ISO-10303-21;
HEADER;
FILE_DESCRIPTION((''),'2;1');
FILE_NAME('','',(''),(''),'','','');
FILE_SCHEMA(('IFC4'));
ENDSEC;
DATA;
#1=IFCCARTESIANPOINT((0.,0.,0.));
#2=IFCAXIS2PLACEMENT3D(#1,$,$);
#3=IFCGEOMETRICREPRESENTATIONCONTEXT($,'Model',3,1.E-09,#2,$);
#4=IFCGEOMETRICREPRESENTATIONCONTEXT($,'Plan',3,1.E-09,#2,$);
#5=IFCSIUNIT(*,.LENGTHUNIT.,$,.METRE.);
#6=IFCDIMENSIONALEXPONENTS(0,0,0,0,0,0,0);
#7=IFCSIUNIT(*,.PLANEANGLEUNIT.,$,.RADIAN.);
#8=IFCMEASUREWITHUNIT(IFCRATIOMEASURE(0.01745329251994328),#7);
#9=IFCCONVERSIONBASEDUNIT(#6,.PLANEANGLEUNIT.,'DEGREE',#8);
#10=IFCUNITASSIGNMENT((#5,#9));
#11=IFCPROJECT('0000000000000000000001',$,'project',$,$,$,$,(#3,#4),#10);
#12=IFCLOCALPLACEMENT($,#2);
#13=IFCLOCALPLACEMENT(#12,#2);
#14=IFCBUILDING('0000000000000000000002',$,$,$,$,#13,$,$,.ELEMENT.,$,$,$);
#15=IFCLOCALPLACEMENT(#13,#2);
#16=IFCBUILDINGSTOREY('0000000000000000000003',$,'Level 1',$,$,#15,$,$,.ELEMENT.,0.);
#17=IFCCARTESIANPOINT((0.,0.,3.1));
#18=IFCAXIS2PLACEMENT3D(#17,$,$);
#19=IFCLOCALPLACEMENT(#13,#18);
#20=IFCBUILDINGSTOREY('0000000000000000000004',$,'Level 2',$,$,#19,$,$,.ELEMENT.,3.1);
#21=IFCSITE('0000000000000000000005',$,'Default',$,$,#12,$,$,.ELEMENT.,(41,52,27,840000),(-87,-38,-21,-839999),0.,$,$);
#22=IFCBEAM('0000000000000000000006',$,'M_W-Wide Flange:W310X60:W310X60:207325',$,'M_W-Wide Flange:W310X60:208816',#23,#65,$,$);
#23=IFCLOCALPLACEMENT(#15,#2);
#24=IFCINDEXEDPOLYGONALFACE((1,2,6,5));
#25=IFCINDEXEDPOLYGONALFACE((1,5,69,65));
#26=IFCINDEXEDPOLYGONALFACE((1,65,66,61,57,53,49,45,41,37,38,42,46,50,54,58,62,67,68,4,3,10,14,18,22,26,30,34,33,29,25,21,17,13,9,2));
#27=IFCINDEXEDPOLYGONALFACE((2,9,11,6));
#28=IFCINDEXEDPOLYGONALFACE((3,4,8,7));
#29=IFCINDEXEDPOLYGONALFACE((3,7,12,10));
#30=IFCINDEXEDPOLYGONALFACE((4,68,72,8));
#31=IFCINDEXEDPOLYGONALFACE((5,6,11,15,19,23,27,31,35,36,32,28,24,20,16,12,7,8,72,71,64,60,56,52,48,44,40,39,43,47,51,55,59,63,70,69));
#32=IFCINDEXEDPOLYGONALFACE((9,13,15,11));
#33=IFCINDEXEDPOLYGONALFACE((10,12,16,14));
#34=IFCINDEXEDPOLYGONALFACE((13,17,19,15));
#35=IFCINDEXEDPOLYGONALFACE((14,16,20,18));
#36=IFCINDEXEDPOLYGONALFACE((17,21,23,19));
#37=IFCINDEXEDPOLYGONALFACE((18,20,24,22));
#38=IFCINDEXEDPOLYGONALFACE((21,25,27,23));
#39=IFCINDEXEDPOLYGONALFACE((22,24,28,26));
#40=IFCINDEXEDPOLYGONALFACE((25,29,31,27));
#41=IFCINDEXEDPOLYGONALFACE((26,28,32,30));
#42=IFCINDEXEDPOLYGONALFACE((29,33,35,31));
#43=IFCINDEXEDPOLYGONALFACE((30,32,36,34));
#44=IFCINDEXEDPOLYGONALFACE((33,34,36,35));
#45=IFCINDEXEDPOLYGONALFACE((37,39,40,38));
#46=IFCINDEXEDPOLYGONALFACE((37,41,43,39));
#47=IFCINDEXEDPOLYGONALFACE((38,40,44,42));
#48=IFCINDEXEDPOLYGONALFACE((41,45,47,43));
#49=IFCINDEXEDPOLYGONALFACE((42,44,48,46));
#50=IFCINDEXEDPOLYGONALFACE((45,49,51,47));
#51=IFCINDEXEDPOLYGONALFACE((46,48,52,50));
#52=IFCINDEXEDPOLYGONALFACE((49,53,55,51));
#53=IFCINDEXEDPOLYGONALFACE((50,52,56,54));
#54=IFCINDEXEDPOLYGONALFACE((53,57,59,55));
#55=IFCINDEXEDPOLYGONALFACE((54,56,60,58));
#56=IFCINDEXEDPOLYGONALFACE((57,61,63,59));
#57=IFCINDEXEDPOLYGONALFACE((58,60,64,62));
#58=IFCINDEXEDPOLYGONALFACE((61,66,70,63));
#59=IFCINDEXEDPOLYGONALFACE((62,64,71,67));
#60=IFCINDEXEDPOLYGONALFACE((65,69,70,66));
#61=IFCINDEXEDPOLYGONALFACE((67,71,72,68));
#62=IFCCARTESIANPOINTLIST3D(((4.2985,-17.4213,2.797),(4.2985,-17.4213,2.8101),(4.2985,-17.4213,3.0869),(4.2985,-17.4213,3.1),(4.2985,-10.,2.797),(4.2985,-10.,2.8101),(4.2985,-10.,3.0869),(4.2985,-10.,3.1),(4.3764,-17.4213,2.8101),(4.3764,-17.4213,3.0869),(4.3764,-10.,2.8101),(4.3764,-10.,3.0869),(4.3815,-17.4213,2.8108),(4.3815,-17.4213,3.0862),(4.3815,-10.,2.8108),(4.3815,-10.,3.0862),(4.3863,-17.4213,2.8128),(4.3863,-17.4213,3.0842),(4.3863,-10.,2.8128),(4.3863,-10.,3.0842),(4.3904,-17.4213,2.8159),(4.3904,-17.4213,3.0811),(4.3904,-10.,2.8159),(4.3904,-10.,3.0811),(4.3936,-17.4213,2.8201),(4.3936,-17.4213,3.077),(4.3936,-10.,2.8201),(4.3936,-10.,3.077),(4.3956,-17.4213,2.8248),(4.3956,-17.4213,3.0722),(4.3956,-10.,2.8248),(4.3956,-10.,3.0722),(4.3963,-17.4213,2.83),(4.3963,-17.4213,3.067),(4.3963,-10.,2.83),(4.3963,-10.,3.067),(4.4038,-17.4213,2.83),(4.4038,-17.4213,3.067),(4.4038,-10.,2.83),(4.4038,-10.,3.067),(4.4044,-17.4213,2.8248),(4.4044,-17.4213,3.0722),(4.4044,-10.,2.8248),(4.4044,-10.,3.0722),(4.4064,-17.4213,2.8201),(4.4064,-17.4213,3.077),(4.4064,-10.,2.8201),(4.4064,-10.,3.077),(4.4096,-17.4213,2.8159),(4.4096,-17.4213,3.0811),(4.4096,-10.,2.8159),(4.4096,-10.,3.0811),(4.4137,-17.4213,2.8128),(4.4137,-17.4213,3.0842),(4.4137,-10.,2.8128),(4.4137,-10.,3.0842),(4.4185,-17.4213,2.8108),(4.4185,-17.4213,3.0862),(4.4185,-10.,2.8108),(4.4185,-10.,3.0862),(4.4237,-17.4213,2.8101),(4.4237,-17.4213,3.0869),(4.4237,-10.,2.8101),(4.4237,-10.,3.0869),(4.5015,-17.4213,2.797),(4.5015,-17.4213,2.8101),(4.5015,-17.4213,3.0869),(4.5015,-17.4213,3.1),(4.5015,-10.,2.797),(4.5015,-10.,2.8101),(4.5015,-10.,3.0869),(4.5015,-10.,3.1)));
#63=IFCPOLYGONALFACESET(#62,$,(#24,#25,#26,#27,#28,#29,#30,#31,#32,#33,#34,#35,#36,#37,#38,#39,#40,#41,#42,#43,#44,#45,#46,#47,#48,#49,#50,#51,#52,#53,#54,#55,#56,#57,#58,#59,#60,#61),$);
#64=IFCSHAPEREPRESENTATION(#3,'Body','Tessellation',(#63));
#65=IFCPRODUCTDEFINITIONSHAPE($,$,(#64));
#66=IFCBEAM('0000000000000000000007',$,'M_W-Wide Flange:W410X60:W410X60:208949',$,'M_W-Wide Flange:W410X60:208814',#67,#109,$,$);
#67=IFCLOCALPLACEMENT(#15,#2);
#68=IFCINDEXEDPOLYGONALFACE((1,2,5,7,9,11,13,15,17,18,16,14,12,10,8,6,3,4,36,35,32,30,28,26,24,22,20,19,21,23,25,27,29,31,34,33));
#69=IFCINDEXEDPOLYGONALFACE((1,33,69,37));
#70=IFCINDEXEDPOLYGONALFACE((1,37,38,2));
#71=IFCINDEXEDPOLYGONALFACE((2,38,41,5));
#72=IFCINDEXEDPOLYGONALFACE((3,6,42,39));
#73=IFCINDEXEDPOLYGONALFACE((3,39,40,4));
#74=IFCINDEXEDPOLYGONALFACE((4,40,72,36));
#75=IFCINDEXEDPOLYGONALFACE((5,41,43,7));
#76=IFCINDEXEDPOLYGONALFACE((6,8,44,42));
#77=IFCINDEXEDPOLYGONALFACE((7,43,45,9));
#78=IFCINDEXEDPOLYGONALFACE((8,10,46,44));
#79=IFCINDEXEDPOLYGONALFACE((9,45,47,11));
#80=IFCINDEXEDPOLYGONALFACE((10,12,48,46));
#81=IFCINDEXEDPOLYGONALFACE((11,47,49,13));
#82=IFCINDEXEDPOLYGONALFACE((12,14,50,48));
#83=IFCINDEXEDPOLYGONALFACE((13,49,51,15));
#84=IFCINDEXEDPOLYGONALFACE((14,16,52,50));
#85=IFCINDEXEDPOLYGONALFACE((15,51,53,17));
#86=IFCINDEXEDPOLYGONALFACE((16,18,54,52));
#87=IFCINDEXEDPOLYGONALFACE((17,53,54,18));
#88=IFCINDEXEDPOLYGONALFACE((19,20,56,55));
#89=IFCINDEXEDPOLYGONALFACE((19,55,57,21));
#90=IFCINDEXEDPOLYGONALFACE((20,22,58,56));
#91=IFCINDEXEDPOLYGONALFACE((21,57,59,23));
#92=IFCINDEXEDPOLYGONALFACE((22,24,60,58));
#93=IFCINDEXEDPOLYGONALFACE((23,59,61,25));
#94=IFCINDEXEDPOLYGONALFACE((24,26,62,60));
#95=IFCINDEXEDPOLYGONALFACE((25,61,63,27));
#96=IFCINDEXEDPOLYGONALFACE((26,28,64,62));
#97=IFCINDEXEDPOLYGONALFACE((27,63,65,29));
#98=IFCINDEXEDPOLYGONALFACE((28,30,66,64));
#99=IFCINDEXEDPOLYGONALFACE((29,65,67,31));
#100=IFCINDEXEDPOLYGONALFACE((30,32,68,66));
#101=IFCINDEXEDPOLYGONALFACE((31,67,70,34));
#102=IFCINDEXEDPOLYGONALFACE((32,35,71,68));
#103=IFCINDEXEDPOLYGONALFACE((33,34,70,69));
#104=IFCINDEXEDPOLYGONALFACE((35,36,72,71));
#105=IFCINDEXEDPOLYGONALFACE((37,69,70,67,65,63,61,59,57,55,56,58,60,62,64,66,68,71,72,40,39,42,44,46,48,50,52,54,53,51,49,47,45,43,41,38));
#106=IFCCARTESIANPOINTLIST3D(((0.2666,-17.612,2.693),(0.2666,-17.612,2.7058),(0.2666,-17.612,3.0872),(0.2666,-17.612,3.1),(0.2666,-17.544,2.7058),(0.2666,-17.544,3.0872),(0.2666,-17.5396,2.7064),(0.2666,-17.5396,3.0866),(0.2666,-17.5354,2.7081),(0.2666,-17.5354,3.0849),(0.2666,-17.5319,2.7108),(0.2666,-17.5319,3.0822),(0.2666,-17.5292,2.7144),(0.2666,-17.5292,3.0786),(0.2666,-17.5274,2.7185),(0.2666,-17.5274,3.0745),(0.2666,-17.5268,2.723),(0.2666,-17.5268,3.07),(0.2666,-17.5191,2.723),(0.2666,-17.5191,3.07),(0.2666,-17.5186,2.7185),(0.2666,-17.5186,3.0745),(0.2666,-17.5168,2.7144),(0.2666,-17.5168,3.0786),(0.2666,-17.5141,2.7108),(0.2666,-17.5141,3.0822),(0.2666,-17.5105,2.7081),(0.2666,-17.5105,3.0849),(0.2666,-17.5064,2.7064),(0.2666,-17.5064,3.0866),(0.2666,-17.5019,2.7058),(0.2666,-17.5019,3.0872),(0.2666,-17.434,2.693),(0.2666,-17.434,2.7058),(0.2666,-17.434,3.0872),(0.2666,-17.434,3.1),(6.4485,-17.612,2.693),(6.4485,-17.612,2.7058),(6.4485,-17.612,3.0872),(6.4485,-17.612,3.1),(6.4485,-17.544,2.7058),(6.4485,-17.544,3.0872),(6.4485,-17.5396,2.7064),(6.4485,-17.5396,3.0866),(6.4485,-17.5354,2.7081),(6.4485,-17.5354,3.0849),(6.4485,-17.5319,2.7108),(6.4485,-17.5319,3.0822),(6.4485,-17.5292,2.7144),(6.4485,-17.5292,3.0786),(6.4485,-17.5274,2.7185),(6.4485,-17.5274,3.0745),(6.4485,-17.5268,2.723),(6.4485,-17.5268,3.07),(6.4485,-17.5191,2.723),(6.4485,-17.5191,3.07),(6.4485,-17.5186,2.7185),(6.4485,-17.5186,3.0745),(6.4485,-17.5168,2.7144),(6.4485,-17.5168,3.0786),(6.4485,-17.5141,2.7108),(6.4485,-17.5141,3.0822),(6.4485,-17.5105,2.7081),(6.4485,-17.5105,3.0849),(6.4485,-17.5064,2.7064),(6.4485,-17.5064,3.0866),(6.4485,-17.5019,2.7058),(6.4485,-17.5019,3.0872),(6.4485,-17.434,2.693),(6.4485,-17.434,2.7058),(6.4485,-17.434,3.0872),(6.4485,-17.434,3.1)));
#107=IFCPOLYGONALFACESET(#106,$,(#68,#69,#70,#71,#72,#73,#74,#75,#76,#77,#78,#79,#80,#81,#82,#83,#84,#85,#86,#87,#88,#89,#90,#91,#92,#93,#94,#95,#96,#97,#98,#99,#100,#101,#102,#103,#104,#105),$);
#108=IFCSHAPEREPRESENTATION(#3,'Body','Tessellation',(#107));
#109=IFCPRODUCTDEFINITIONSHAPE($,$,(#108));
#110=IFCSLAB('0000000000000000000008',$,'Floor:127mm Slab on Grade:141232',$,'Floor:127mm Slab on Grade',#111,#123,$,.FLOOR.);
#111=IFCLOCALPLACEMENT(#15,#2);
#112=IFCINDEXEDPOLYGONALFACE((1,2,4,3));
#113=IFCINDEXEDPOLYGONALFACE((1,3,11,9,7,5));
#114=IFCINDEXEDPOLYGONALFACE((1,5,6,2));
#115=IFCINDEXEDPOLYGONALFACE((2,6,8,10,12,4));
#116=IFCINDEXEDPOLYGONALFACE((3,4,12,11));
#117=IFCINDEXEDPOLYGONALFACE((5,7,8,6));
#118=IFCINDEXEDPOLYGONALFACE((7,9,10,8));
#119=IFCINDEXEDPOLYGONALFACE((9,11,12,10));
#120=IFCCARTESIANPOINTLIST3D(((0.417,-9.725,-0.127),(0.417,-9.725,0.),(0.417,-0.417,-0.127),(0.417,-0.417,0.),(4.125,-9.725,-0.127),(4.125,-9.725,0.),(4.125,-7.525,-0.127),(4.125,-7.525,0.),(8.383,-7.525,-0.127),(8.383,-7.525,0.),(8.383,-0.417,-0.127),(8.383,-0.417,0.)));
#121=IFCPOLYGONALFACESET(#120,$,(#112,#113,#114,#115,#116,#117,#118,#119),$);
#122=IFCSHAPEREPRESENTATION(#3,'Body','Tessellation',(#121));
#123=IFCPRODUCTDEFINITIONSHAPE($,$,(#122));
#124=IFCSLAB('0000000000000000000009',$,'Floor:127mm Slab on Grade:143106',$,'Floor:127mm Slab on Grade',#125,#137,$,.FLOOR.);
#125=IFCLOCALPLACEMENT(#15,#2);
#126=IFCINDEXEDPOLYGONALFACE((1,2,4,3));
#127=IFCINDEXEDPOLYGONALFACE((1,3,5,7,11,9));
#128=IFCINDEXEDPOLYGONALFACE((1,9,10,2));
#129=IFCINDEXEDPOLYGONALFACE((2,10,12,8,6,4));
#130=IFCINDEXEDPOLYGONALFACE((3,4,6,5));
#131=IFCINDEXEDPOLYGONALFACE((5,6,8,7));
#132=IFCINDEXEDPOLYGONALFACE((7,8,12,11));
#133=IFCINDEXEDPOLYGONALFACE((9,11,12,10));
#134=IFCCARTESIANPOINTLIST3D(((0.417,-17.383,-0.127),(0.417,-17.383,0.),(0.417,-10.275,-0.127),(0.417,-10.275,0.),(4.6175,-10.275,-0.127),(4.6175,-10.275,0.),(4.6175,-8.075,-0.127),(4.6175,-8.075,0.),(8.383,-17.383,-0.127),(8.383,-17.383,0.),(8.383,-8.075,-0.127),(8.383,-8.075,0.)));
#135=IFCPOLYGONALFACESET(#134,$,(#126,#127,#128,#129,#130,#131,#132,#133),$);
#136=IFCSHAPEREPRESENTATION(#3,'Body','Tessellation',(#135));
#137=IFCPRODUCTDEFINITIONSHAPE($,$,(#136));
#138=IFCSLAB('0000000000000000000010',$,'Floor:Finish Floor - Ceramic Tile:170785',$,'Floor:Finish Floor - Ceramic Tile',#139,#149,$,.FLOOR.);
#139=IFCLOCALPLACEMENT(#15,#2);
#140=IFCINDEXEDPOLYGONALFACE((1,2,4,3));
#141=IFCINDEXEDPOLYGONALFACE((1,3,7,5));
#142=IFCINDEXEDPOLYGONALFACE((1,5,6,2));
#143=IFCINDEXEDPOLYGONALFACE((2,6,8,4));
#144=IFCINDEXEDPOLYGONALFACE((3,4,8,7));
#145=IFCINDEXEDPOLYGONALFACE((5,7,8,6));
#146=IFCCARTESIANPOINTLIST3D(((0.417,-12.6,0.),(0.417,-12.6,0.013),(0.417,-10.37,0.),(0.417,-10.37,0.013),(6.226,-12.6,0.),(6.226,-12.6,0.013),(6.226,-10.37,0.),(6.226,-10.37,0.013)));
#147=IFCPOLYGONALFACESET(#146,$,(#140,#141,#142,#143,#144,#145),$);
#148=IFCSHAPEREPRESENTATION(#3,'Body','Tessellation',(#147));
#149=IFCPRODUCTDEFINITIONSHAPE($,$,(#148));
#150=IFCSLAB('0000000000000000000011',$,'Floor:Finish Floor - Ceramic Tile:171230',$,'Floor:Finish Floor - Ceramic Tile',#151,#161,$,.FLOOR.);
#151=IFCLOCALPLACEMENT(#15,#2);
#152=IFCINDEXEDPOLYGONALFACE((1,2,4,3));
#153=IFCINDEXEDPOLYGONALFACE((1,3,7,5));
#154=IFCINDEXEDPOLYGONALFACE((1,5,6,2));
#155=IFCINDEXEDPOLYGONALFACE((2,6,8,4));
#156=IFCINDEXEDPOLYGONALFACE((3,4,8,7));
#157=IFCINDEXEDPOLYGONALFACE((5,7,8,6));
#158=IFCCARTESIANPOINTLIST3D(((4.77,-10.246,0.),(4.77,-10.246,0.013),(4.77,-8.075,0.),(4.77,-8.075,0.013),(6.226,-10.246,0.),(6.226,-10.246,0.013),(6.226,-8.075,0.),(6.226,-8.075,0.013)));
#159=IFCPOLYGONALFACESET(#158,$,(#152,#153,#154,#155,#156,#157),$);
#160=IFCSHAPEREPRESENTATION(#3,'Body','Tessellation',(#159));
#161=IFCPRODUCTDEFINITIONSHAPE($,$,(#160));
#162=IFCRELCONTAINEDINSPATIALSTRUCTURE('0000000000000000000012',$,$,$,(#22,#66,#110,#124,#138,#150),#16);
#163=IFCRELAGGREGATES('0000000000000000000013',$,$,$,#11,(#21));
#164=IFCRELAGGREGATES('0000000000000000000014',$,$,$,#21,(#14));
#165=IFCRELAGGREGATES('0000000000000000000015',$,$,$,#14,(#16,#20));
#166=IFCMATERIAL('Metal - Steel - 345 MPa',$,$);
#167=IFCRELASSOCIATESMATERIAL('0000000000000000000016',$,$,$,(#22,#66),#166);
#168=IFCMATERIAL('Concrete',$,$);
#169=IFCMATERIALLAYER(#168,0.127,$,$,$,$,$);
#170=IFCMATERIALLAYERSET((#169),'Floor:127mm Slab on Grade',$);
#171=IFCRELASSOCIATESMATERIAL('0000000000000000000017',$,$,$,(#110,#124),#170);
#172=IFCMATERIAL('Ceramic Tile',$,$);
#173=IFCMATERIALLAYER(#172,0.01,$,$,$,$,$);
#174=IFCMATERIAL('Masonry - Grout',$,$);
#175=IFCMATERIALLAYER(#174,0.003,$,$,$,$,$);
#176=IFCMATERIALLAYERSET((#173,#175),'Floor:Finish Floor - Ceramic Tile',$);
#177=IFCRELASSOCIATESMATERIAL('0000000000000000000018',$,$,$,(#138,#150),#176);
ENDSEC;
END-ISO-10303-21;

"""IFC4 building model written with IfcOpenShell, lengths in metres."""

from ifc_helpers import new_model, entity, si_unit, converted_unit, frame, frame_2d, origin, place, context, project, spatial, polyline, circle_curve, parameter, trimmed, segment, composite_curve, rectangle, outline, extrude, material, layer, layer_set, layer_usage, element, save


model = new_model("IFC4")

# Units and contexts
model_context = context("Model", 3, precision=1e-09, world=origin())
plan_context = context("Plan", 3, precision=1e-09, world=origin())
ifc_project = project(units=[si_unit("LENGTHUNIT", "METRE"), converted_unit("PLANEANGLEUNIT", "DEGREE", entity("IfcRatioMeasure", 0.01745329251994328), si_unit("PLANEANGLEUNIT", "RADIAN"), dimensions=[0, 0, 0, 0, 0, 0, 0])], contexts=[model_context, plan_context])

# Site, building, storey
site_placement = place(None, origin())
site = spatial("IfcSite", under=ifc_project, at=site_placement, Name="Default", CompositionType="ELEMENT", RefLatitude=(41, 52, 27, 840000), RefLongitude=(-87, -38, -21, -839999), RefElevation=0.0)
building_placement = place(site_placement, origin())
building = spatial("IfcBuilding", under=site, at=building_placement, CompositionType="ELEMENT")
storey_1_placement = place(building_placement, origin())
storey_1 = spatial("IfcBuildingStorey", under=building, at=storey_1_placement, Name="Level 1", CompositionType="ELEMENT", Elevation=0.0)

# Beams
ifc_material_1 = material(Name="Metal - Steel - 345 MPa")
beam_1_placement = place(storey_1_placement, frame((4.4, -10.0, 3.1), z_axis=(0.0, 0.0, 1.0), x_axis=(-1.0, 0.0, 0.0)))
element("IfcBeam", 1, at=beam_1_placement, inside=storey_1, material=ifc_material_1, Name="M_W-Wide Flange:W310X60:W310X60:207325", ObjectType="M_W-Wide Flange:W310X60:208816", context=model_context, shape_type="SweptSolid", body=[
    extrude(outline(composite_curve([segment(polyline([(0.1384, -0.1015), (0.1515, -0.1015)]), True, "CONTINUOUS"), segment(polyline([(0.1515, -0.1015), (0.1515, 0.1015)]), True, "CONTINUOUS"), segment(polyline([(0.1515, 0.1015), (0.1384, 0.1015)]), True, "CONTINUOUS"), segment(polyline([(0.1384, 0.1015), (0.1384, 0.0236)]), True, "CONTINUOUS"), segment(trimmed(circle_curve(frame_2d((0.1185, 0.0236), x_axis=(0.0, 1.0)), 0.0199), [parameter(180.0)], [parameter(270.0)], True, "PARAMETER"), False, "CONTINUOUS"), segment(polyline([(0.1185, 0.0037), (-0.1185, 0.0037)]), True, "CONTINUOUS"), segment(trimmed(circle_curve(frame_2d((-0.1185, 0.0236), x_axis=(0.0, 1.0)), 0.0199), [parameter(90.0)], [parameter(180.0)], True, "PARAMETER"), False, "CONTINUOUS"), segment(polyline([(-0.1384, 0.0236), (-0.1384, 0.1015)]), True, "CONTINUOUS"), segment(polyline([(-0.1384, 0.1015), (-0.1515, 0.1015)]), True, "CONTINUOUS"), segment(polyline([(-0.1515, 0.1015), (-0.1515, -0.1015)]), True, "CONTINUOUS"), segment(polyline([(-0.1515, -0.1015), (-0.1384, -0.1015)]), True, "CONTINUOUS"), segment(polyline([(-0.1384, -0.1015), (-0.1384, -0.0237)]), True, "CONTINUOUS"), segment(trimmed(circle_curve(frame_2d((-0.1185, -0.0237), x_axis=(0.0, 1.0)), 0.0199), [parameter(360.0)], [parameter(90.0)], True, "PARAMETER"), False, "CONTINUOUS"), segment(polyline([(-0.1185, -0.0038), (0.1185, -0.0038)]), True, "CONTINUOUS"), segment(trimmed(circle_curve(frame_2d((0.1185, -0.0237), x_axis=(0.0, 1.0)), 0.0199), [parameter(270.0)], [parameter(0.0)], True, "PARAMETER"), False, "CONTINUOUS"), segment(polyline([(0.1384, -0.0237), (0.1384, -0.1015)]), True, "CONTINUOUS")], self_intersect=False)), frame((0.0, 7.4213, -0.1515), z_axis=(0.0, -1.0, 0.0), x_axis=(0.0, 0.0, -1.0)), (0.0, 0.0, 1.0), 7.4213),
])
beam_2_placement = place(storey_1_placement, frame((0.2085, -17.523, 3.1), z_axis=(0.0, 0.0, 1.0), x_axis=(0.0, -1.0, 0.0)))
element("IfcBeam", 2, at=beam_2_placement, inside=storey_1, material=ifc_material_1, Name="M_W-Wide Flange:W410X60:W410X60:208949", ObjectType="M_W-Wide Flange:W410X60:208814", context=model_context, shape_type="SweptSolid", body=[
    extrude(outline(composite_curve([segment(polyline([(-0.089, -0.1907), (-0.089, -0.2035)]), True, "CONTINUOUS"), segment(polyline([(-0.089, -0.2035), (0.089, -0.2035)]), True, "CONTINUOUS"), segment(polyline([(0.089, -0.2035), (0.089, -0.1907)]), True, "CONTINUOUS"), segment(polyline([(0.089, -0.1907), (0.021, -0.1907)]), True, "CONTINUOUS"), segment(trimmed(circle_curve(frame_2d((0.021, -0.1735), x_axis=(0.0, -1.0)), 0.0172), [parameter(270.0)], [parameter(360.0)], True, "PARAMETER"), False, "CONTINUOUS"), segment(polyline([(0.0038, -0.1735), (0.0038, 0.1735)]), True, "CONTINUOUS"), segment(trimmed(circle_curve(frame_2d((0.021, 0.1735), x_axis=(-1.0, 0.0)), 0.0172), [parameter(270.0)], [parameter(360.0)], True, "PARAMETER"), False, "CONTINUOUS"), segment(polyline([(0.021, 0.1907), (0.089, 0.1907)]), True, "CONTINUOUS"), segment(polyline([(0.089, 0.1907), (0.089, 0.2035)]), True, "CONTINUOUS"), segment(polyline([(0.089, 0.2035), (-0.089, 0.2035)]), True, "CONTINUOUS"), segment(polyline([(-0.089, 0.2035), (-0.089, 0.1907)]), True, "CONTINUOUS"), segment(polyline([(-0.089, 0.1907), (-0.0211, 0.1907)]), True, "CONTINUOUS"), segment(trimmed(circle_curve(frame_2d((-0.0211, 0.1735), x_axis=(0.0, 1.0)), 0.0172), [parameter(270.0)], [parameter(0.0)], True, "PARAMETER"), False, "CONTINUOUS"), segment(polyline([(-0.0039, 0.1735), (-0.0039, -0.1735)]), True, "CONTINUOUS"), segment(trimmed(circle_curve(frame_2d((-0.0211, -0.1735), x_axis=(1.0, 0.0)), 0.0172), [parameter(270.0)], [parameter(0.0)], True, "PARAMETER"), False, "CONTINUOUS"), segment(polyline([(-0.0211, -0.1907), (-0.089, -0.1907)]), True, "CONTINUOUS")], self_intersect=False)), frame((0.0, 0.0581, -0.2035), z_axis=(0.0, -1.0, 0.0), x_axis=(1.0, 0.0, 0.0)), (0.0, 0.0, -1.0), 6.1819),
])

# Slabs
ifc_material_2 = material(Name="Concrete")
ifc_layer_1 = layer(ifc_material_2, 0.127)
ifc_layer_set_1 = layer_set([ifc_layer_1], Name="Floor:127mm Slab on Grade")
ifc_layer_usage_1 = layer_usage(ifc_layer_set_1, "AXIS3", "POSITIVE", 0.0)
slab_1_placement = place(storey_1_placement, frame((0.417, -9.725, -0.127)))
element("IfcSlab", 3, at=slab_1_placement, inside=storey_1, material=ifc_layer_usage_1, Name="Floor:127mm Slab on Grade:141232", ObjectType="Floor:127mm Slab on Grade", PredefinedType="FLOOR", context=model_context, shape_type="SweptSolid", body=[
    extrude(outline(polyline([(-3.983, 4.654), (-3.983, -2.454), (0.275, -2.454), (0.275, -4.654), (3.983, -4.654), (3.983, 4.654), (-3.983, 4.654)])), frame((3.983, 4.654, 0.127), z_axis=(0.0, 0.0, -1.0), x_axis=(-1.0, 0.0, 0.0)), (0.0, 0.0, 1.0), 0.127),
])
ifc_layer_usage_2 = layer_usage(ifc_layer_set_1, "AXIS3", "POSITIVE", 0.0)
slab_2_placement = place(storey_1_placement, frame((0.417, -17.383, -0.127)))
element("IfcSlab", 4, at=slab_2_placement, inside=storey_1, material=ifc_layer_usage_2, Name="Floor:127mm Slab on Grade:143106", ObjectType="Floor:127mm Slab on Grade", PredefinedType="FLOOR", context=model_context, shape_type="SweptSolid", body=[
    extrude(outline(polyline([(-3.983, 4.654), (-3.983, -4.654), (3.983, -4.654), (3.983, 2.454), (-0.2175, 2.454), (-0.2175, 4.654), (-3.983, 4.654)])), frame((3.983, 4.654, 0.127), z_axis=(0.0, 0.0, -1.0), x_axis=(-1.0, 0.0, 0.0)), (0.0, 0.0, 1.0), 0.127),
])
ifc_material_3 = material(Name="Ceramic Tile")
ifc_layer_2 = layer(ifc_material_3, 0.01)
ifc_material_4 = material(Name="Masonry - Grout")
ifc_layer_3 = layer(ifc_material_4, 0.003)
ifc_layer_set_2 = layer_set([ifc_layer_2, ifc_layer_3], Name="Floor:Finish Floor - Ceramic Tile")
ifc_layer_usage_3 = layer_usage(ifc_layer_set_2, "AXIS3", "POSITIVE", 0.0)
slab_3_placement = place(storey_1_placement, frame((0.417, -12.6, 0.0)))
element("IfcSlab", 5, at=slab_3_placement, inside=storey_1, material=ifc_layer_usage_3, Name="Floor:Finish Floor - Ceramic Tile:170785", ObjectType="Floor:Finish Floor - Ceramic Tile", PredefinedType="FLOOR", context=model_context, shape_type="SweptSolid", body=[
    extrude(rectangle(XDim=5.809, YDim=2.23, at=frame_2d((0.0, 0.0), x_axis=(-1.0, 0.0))), frame((2.9045, 1.115, 0.013), z_axis=(0.0, 0.0, -1.0), x_axis=(-1.0, 0.0, 0.0)), (0.0, 0.0, 1.0), 0.013),
])
ifc_layer_usage_4 = layer_usage(ifc_layer_set_2, "AXIS3", "POSITIVE", 0.0)
slab_4_placement = place(storey_1_placement, frame((4.77, -10.246, 0.0)))
element("IfcSlab", 6, at=slab_4_placement, inside=storey_1, material=ifc_layer_usage_4, Name="Floor:Finish Floor - Ceramic Tile:171230", ObjectType="Floor:Finish Floor - Ceramic Tile", PredefinedType="FLOOR", context=model_context, shape_type="SweptSolid", body=[
    extrude(rectangle(XDim=1.456, YDim=2.171, at=frame_2d((0.0, 0.0), x_axis=(-1.0, 0.0))), frame((0.728, 1.0855, 0.013), z_axis=(0.0, 0.0, -1.0), x_axis=(-1.0, 0.0, 0.0)), (0.0, 0.0, 1.0), 0.013),
])

# Shared definitions
storey_2_placement = place(building_placement, frame((0.0, 0.0, 3.1)))
storey_2 = spatial("IfcBuildingStorey", under=building, at=storey_2_placement, Name="Level 2", CompositionType="ELEMENT", Elevation=3.1)

save(model, "model.ifc")
